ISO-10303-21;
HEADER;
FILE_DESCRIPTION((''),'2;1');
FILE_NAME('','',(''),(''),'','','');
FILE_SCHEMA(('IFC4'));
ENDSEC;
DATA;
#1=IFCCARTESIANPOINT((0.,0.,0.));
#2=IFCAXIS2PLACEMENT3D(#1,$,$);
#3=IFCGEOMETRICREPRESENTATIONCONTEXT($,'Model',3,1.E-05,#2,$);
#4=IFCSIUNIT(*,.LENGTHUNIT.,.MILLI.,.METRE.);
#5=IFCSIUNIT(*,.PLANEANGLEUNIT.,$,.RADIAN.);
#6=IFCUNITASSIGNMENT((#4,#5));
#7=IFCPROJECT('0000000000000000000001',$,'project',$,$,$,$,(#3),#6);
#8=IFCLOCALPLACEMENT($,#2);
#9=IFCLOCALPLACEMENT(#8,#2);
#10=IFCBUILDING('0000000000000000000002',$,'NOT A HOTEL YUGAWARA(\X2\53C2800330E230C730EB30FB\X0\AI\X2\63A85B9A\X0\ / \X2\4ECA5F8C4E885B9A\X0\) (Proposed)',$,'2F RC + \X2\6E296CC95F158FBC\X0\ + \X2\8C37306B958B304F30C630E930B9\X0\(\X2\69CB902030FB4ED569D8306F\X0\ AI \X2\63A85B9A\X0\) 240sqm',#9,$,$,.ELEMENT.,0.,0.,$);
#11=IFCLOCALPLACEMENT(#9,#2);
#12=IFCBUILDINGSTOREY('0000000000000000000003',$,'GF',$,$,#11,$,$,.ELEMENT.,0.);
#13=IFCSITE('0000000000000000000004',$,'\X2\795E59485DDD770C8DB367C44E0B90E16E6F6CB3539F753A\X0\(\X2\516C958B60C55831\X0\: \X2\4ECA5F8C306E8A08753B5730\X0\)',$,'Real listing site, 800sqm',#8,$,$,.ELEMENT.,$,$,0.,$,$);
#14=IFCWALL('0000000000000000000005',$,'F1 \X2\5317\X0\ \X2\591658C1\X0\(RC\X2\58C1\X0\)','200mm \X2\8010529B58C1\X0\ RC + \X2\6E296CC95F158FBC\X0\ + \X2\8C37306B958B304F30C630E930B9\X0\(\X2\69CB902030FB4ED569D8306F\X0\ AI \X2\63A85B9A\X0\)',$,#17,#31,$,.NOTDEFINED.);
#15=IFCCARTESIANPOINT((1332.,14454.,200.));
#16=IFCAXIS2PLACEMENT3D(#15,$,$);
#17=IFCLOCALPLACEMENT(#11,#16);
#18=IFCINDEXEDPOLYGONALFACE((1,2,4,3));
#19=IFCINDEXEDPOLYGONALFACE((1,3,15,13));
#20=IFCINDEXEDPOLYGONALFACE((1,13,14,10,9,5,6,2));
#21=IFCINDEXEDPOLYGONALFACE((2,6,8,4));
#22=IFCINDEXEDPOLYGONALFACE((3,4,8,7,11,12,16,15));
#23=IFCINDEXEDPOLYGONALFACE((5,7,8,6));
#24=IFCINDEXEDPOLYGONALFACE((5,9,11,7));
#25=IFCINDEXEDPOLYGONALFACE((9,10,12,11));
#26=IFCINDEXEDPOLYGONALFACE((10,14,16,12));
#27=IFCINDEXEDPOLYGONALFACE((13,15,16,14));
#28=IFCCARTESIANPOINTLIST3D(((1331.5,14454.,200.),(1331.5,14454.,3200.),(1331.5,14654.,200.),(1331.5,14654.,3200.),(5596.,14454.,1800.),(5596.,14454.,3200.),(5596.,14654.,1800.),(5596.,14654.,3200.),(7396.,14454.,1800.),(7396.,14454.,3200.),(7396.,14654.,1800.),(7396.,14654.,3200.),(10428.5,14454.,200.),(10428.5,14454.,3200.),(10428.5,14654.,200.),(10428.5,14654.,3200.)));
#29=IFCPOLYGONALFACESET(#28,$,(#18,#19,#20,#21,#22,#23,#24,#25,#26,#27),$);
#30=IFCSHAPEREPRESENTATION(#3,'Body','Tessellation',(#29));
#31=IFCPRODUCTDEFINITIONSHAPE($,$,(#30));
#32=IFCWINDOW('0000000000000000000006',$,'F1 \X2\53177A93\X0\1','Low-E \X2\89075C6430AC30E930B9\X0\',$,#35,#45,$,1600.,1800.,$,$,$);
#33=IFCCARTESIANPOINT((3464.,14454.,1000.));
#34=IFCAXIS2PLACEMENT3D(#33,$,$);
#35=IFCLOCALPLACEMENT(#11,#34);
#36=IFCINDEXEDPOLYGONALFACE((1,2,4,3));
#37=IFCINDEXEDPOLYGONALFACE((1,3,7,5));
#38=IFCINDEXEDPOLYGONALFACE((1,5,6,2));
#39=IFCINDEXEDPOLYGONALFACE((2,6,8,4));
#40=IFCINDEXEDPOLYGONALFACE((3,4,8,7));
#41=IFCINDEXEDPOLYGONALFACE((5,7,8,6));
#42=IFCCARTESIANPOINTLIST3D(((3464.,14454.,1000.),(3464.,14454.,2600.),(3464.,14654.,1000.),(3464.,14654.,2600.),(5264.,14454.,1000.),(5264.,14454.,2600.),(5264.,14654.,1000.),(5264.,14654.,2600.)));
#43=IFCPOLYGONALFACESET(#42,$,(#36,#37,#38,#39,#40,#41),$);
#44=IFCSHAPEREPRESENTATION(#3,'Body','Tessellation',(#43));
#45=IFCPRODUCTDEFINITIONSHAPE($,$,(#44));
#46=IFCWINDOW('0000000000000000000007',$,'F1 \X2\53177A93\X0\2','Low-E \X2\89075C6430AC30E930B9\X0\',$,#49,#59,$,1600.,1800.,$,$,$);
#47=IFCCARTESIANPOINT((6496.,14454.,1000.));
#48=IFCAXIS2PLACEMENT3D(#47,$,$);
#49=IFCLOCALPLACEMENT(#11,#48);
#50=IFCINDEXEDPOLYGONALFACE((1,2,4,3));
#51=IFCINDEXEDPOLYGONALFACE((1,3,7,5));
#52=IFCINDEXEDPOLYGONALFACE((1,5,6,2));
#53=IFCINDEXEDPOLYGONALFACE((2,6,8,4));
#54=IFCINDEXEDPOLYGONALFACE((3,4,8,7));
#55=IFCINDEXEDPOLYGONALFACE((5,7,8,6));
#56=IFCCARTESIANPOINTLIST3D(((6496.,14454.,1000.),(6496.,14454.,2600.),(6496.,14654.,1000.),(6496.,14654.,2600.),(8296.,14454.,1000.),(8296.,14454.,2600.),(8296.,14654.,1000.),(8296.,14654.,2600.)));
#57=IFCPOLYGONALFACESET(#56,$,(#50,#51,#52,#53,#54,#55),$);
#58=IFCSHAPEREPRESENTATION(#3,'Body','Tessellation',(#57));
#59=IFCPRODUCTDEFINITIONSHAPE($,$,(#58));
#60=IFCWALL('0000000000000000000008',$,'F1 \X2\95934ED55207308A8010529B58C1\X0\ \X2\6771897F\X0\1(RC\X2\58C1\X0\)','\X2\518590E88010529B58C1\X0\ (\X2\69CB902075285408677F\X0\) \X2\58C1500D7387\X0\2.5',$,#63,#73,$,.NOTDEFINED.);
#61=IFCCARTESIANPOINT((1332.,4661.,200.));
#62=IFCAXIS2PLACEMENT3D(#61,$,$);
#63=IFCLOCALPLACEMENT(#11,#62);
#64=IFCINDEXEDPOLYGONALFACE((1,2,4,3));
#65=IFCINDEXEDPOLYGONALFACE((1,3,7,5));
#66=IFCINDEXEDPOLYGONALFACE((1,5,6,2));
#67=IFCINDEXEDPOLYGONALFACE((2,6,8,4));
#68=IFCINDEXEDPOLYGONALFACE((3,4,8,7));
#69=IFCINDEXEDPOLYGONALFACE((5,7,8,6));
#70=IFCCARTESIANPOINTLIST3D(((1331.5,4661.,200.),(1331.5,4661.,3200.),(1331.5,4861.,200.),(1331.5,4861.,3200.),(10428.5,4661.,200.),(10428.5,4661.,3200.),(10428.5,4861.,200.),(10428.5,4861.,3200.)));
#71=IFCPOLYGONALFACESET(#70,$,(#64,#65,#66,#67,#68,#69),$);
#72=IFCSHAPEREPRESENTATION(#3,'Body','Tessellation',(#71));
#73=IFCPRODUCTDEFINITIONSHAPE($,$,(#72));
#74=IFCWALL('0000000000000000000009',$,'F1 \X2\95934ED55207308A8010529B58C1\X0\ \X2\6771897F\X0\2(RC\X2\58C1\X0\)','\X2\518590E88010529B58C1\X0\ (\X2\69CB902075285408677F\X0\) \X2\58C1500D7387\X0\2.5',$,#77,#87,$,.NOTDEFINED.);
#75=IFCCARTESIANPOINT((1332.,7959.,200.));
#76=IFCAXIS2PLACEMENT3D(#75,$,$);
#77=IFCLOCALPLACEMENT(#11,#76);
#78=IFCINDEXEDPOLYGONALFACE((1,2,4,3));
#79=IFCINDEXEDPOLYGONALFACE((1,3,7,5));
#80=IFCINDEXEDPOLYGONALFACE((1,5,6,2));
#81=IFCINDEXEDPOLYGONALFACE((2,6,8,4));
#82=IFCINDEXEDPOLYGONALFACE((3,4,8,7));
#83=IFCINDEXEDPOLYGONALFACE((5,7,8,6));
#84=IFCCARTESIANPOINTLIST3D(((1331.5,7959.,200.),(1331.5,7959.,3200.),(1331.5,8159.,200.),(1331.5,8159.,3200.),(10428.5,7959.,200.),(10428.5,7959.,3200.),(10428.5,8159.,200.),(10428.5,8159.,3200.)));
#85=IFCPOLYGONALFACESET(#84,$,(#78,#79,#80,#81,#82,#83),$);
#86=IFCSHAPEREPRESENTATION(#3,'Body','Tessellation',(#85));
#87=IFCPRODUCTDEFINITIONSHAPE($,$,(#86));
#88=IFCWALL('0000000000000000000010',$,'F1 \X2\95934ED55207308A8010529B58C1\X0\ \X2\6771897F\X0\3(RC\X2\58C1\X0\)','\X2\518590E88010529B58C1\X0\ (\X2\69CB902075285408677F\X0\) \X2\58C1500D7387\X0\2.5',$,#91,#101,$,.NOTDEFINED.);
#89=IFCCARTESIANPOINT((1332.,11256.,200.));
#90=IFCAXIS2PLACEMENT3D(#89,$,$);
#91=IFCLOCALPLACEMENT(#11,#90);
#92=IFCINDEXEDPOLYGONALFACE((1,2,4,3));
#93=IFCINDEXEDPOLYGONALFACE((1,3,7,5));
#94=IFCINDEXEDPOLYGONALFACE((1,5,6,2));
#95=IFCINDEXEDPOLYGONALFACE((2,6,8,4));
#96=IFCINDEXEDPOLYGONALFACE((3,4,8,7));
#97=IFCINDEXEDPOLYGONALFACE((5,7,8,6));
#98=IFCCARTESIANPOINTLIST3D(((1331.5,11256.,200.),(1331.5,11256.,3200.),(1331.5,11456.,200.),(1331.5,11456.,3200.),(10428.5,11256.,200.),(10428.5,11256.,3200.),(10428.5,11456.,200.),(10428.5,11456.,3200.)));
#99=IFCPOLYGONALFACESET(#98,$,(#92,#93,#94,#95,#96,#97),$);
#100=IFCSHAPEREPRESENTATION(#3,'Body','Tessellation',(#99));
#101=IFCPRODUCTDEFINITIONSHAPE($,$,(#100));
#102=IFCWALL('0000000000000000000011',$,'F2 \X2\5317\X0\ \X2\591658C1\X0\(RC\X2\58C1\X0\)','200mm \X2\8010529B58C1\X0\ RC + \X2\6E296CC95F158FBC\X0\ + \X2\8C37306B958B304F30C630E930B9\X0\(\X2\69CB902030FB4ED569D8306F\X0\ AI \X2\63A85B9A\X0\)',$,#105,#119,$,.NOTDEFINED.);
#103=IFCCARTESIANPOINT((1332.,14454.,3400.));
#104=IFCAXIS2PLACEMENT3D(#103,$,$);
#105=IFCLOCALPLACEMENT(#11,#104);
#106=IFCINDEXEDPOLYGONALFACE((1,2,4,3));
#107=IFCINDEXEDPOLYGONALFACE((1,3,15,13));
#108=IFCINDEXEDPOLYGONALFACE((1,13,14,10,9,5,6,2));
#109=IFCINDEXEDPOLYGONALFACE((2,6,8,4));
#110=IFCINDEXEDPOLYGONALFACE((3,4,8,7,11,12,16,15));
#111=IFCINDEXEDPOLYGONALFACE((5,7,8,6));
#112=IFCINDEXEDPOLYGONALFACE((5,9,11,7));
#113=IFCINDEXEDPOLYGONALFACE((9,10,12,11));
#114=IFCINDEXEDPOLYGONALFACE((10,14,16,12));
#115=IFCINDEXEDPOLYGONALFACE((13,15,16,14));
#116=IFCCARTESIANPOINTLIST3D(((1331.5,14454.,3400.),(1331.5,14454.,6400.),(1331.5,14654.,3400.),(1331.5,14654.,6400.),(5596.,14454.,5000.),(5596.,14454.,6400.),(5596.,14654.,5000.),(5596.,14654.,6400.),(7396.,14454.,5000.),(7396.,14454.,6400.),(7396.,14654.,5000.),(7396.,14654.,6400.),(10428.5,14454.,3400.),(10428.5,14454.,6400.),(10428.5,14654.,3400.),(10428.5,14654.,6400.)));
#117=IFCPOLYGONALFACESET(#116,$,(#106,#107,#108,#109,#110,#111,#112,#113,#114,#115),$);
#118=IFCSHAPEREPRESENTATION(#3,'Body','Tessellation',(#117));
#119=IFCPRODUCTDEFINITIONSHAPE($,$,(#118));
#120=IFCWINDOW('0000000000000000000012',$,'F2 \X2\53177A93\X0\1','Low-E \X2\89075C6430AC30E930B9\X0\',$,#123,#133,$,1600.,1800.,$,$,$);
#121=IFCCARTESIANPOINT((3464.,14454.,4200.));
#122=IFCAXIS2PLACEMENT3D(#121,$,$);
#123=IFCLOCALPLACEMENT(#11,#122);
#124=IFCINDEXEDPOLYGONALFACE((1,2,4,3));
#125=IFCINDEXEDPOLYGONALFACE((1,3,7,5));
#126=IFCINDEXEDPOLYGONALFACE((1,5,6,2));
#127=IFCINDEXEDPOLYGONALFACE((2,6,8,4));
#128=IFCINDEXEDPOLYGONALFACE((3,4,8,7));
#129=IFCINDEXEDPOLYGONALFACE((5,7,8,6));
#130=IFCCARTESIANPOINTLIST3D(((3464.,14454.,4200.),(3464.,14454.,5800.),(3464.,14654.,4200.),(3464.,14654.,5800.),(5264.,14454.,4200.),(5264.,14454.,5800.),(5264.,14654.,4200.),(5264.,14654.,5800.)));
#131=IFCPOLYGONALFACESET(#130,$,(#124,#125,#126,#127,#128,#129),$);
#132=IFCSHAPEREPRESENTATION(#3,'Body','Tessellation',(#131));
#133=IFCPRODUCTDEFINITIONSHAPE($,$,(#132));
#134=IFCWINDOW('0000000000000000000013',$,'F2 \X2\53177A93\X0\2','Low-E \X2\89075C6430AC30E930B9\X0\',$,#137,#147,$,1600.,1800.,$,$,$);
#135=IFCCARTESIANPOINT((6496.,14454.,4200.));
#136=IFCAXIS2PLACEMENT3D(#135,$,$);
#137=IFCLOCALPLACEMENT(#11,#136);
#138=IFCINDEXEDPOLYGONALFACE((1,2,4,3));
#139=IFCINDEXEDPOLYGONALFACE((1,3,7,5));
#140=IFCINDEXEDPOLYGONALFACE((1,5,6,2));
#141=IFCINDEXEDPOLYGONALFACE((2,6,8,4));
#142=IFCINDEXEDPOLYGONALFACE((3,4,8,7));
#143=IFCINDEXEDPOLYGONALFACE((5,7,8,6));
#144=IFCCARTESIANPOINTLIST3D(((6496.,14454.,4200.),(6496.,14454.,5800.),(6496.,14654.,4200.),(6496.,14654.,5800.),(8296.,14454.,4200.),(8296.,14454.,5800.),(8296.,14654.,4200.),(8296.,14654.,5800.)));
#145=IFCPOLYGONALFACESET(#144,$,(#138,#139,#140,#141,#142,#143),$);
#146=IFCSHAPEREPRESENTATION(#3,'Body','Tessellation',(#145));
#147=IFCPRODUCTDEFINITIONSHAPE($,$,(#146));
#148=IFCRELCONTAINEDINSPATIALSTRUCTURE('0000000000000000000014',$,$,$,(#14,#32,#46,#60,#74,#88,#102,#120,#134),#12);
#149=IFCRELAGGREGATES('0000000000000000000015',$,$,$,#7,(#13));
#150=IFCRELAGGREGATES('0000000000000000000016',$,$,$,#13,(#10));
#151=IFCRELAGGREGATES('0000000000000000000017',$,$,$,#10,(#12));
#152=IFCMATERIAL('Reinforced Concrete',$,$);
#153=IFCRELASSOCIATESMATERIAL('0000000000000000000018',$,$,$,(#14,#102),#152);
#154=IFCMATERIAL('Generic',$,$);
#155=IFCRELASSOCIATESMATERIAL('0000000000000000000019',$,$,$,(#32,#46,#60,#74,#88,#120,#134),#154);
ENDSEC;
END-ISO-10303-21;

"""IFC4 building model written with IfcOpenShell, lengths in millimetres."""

from ifc_helpers import new_model, si_unit, frame, frame_2d, origin, place, context, project, spatial, rectangle, extrude, material, element, fill, save


model = new_model("IFC4")

# Units and contexts
model_context = context("Model", 3, precision=1e-05, world=origin())
ifc_project = project(units=[si_unit("LENGTHUNIT", "METRE", prefix="MILLI"), si_unit("PLANEANGLEUNIT", "RADIAN")], contexts=[model_context])

# Site, building, storey
site_placement = place(None, origin())
site = spatial("IfcSite", under=ifc_project, at=site_placement, Name="神奈川県足柄下郡湯河原町(公開情報: 今後の計画地)", ObjectType="Real listing site, 800sqm", CompositionType="ELEMENT", RefElevation=0.0)
building_placement = place(site_placement, origin())
building = spatial("IfcBuilding", under=site, at=building_placement, Name="NOT A HOTEL YUGAWARA(参考モデル・AI推定 / 今後予定) (Proposed)", ObjectType="2F RC + 温泉引込 + 谷に開くテラス(構造・仕様は AI 推定) 240sqm", CompositionType="ELEMENT", ElevationOfRefHeight=0.0, ElevationOfTerrain=0.0)
storey_placement = place(building_placement, origin())
storey = spatial("IfcBuildingStorey", under=building, at=storey_placement, Name="GF", CompositionType="ELEMENT", Elevation=0.0)

# Wall, openings, windows
ifc_material_1 = material(Name="Reinforced Concrete")
wall_1_placement = place(storey_placement, frame((1332.0, 14454.0, 200.0)))
wall_1 = element("IfcWall", 1, at=wall_1_placement, inside=storey, material=ifc_material_1, Name="F1 北 外壁(RC壁)", Description="200mm 耐力壁 RC + 温泉引込 + 谷に開くテラス(構造・仕様は AI 推定)", PredefinedType="NOTDEFINED", context=model_context, shape_type="SweptSolid", body=[
    extrude(rectangle(XDim=9097.0, YDim=200.0, at=frame_2d((4548.0, 100.0))), frame((1332.0, 14454.0, 200.0)), (0.0, 0.0, 1.0), 3000.0),
])
opening_1_placement = place(storey_placement, frame((3464.0, 14454.0, 1000.0)))
opening_1 = element("IfcOpeningElement", 2, at=opening_1_placement, cuts=wall_1, PredefinedType="NOTDEFINED", context=model_context, shape_type="SweptSolid", body=[
    extrude(rectangle(XDim=1800.0, YDim=200.0, at=frame_2d((900.0, 100.0))), frame((3464.0, 14454.0, 1000.0)), (0.0, 0.0, 1.0), 1600.0),
])
opening_2_placement = place(storey_placement, frame((6496.0, 14454.0, 1000.0)))
opening_2 = element("IfcOpeningElement", 3, at=opening_2_placement, cuts=wall_1, PredefinedType="NOTDEFINED", context=model_context, shape_type="SweptSolid", body=[
    extrude(rectangle(XDim=1800.0, YDim=200.0, at=frame_2d((900.0, 100.0))), frame((6496.0, 14454.0, 1000.0)), (0.0, 0.0, 1.0), 1600.0),
])
ifc_material_2 = material(Name="Generic")
window_1_placement = place(storey_placement, frame((3464.0, 14454.0, 1000.0)))
window_1 = element("IfcWindow", 4, at=window_1_placement, inside=storey, material=ifc_material_2, Name="F1 北窓1", Description="Low-E 複層ガラス", OverallHeight=1600.0, OverallWidth=1800.0, context=model_context, shape_type="SweptSolid", body=[
    extrude(rectangle(XDim=1800.0, YDim=200.0, at=frame_2d((900.0, 100.0))), frame((3464.0, 14454.0, 1000.0)), (0.0, 0.0, 1.0), 1600.0),
])
fill(opening_1, window_1)
window_2_placement = place(storey_placement, frame((6496.0, 14454.0, 1000.0)))
window_2 = element("IfcWindow", 5, at=window_2_placement, inside=storey, material=ifc_material_2, Name="F1 北窓2", Description="Low-E 複層ガラス", OverallHeight=1600.0, OverallWidth=1800.0, context=model_context, shape_type="SweptSolid", body=[
    extrude(rectangle(XDim=1800.0, YDim=200.0, at=frame_2d((900.0, 100.0))), frame((6496.0, 14454.0, 1000.0)), (0.0, 0.0, 1.0), 1600.0),
])
fill(opening_2, window_2)

# Walls
wall_2_placement = place(storey_placement, frame((1332.0, 4661.0, 200.0)))
element("IfcWall", 6, at=wall_2_placement, inside=storey, material=ifc_material_2, Name="F1 間仕切り耐力壁 東西1(RC壁)", Description="内部耐力壁 (構造用合板) 壁倍率2.5", PredefinedType="NOTDEFINED", context=model_context, shape_type="SweptSolid", body=[
    extrude(rectangle(XDim=9097.0, YDim=200.0, at=frame_2d((4548.0, 100.0))), frame((1332.0, 4661.0, 200.0)), (0.0, 0.0, 1.0), 3000.0),
])
wall_3_placement = place(storey_placement, frame((1332.0, 7959.0, 200.0)))
element("IfcWall", 7, at=wall_3_placement, inside=storey, material=ifc_material_2, Name="F1 間仕切り耐力壁 東西2(RC壁)", Description="内部耐力壁 (構造用合板) 壁倍率2.5", PredefinedType="NOTDEFINED", context=model_context, shape_type="SweptSolid", body=[
    extrude(rectangle(XDim=9097.0, YDim=200.0, at=frame_2d((4548.0, 100.0))), frame((1332.0, 7959.0, 200.0)), (0.0, 0.0, 1.0), 3000.0),
])
wall_4_placement = place(storey_placement, frame((1332.0, 11256.0, 200.0)))
element("IfcWall", 8, at=wall_4_placement, inside=storey, material=ifc_material_2, Name="F1 間仕切り耐力壁 東西3(RC壁)", Description="内部耐力壁 (構造用合板) 壁倍率2.5", PredefinedType="NOTDEFINED", context=model_context, shape_type="SweptSolid", body=[
    extrude(rectangle(XDim=9097.0, YDim=200.0, at=frame_2d((4548.0, 100.0))), frame((1332.0, 11256.0, 200.0)), (0.0, 0.0, 1.0), 3000.0),
])

# Wall, openings, windows
wall_5_placement = place(storey_placement, frame((1332.0, 14454.0, 3400.0)))
wall_5 = element("IfcWall", 9, at=wall_5_placement, inside=storey, material=ifc_material_1, Name="F2 北 外壁(RC壁)", Description="200mm 耐力壁 RC + 温泉引込 + 谷に開くテラス(構造・仕様は AI 推定)", PredefinedType="NOTDEFINED", context=model_context, shape_type="SweptSolid", body=[
    extrude(rectangle(XDim=9097.0, YDim=200.0, at=frame_2d((4548.0, 100.0))), frame((1332.0, 14454.0, 3400.0)), (0.0, 0.0, 1.0), 3000.0),
])
opening_3_placement = place(storey_placement, frame((3464.0, 14454.0, 4200.0)))
opening_3 = element("IfcOpeningElement", 10, at=opening_3_placement, cuts=wall_5, PredefinedType="NOTDEFINED", context=model_context, shape_type="SweptSolid", body=[
    extrude(rectangle(XDim=1800.0, YDim=200.0, at=frame_2d((900.0, 100.0))), frame((3464.0, 14454.0, 4200.0)), (0.0, 0.0, 1.0), 1600.0),
])
opening_4_placement = place(storey_placement, frame((6496.0, 14454.0, 4200.0)))
opening_4 = element("IfcOpeningElement", 11, at=opening_4_placement, cuts=wall_5, PredefinedType="NOTDEFINED", context=model_context, shape_type="SweptSolid", body=[
    extrude(rectangle(XDim=1800.0, YDim=200.0, at=frame_2d((900.0, 100.0))), frame((6496.0, 14454.0, 4200.0)), (0.0, 0.0, 1.0), 1600.0),
])
window_3_placement = place(storey_placement, frame((3464.0, 14454.0, 4200.0)))
window_3 = element("IfcWindow", 12, at=window_3_placement, inside=storey, material=ifc_material_2, Name="F2 北窓1", Description="Low-E 複層ガラス", OverallHeight=1600.0, OverallWidth=1800.0, context=model_context, shape_type="SweptSolid", body=[
    extrude(rectangle(XDim=1800.0, YDim=200.0, at=frame_2d((900.0, 100.0))), frame((3464.0, 14454.0, 4200.0)), (0.0, 0.0, 1.0), 1600.0),
])
fill(opening_3, window_3)
window_4_placement = place(storey_placement, frame((6496.0, 14454.0, 4200.0)))
window_4 = element("IfcWindow", 13, at=window_4_placement, inside=storey, material=ifc_material_2, Name="F2 北窓2", Description="Low-E 複層ガラス", OverallHeight=1600.0, OverallWidth=1800.0, context=model_context, shape_type="SweptSolid", body=[
    extrude(rectangle(XDim=1800.0, YDim=200.0, at=frame_2d((900.0, 100.0))), frame((6496.0, 14454.0, 4200.0)), (0.0, 0.0, 1.0), 1600.0),
])
fill(opening_4, window_4)

save(model, "model.ifc")
